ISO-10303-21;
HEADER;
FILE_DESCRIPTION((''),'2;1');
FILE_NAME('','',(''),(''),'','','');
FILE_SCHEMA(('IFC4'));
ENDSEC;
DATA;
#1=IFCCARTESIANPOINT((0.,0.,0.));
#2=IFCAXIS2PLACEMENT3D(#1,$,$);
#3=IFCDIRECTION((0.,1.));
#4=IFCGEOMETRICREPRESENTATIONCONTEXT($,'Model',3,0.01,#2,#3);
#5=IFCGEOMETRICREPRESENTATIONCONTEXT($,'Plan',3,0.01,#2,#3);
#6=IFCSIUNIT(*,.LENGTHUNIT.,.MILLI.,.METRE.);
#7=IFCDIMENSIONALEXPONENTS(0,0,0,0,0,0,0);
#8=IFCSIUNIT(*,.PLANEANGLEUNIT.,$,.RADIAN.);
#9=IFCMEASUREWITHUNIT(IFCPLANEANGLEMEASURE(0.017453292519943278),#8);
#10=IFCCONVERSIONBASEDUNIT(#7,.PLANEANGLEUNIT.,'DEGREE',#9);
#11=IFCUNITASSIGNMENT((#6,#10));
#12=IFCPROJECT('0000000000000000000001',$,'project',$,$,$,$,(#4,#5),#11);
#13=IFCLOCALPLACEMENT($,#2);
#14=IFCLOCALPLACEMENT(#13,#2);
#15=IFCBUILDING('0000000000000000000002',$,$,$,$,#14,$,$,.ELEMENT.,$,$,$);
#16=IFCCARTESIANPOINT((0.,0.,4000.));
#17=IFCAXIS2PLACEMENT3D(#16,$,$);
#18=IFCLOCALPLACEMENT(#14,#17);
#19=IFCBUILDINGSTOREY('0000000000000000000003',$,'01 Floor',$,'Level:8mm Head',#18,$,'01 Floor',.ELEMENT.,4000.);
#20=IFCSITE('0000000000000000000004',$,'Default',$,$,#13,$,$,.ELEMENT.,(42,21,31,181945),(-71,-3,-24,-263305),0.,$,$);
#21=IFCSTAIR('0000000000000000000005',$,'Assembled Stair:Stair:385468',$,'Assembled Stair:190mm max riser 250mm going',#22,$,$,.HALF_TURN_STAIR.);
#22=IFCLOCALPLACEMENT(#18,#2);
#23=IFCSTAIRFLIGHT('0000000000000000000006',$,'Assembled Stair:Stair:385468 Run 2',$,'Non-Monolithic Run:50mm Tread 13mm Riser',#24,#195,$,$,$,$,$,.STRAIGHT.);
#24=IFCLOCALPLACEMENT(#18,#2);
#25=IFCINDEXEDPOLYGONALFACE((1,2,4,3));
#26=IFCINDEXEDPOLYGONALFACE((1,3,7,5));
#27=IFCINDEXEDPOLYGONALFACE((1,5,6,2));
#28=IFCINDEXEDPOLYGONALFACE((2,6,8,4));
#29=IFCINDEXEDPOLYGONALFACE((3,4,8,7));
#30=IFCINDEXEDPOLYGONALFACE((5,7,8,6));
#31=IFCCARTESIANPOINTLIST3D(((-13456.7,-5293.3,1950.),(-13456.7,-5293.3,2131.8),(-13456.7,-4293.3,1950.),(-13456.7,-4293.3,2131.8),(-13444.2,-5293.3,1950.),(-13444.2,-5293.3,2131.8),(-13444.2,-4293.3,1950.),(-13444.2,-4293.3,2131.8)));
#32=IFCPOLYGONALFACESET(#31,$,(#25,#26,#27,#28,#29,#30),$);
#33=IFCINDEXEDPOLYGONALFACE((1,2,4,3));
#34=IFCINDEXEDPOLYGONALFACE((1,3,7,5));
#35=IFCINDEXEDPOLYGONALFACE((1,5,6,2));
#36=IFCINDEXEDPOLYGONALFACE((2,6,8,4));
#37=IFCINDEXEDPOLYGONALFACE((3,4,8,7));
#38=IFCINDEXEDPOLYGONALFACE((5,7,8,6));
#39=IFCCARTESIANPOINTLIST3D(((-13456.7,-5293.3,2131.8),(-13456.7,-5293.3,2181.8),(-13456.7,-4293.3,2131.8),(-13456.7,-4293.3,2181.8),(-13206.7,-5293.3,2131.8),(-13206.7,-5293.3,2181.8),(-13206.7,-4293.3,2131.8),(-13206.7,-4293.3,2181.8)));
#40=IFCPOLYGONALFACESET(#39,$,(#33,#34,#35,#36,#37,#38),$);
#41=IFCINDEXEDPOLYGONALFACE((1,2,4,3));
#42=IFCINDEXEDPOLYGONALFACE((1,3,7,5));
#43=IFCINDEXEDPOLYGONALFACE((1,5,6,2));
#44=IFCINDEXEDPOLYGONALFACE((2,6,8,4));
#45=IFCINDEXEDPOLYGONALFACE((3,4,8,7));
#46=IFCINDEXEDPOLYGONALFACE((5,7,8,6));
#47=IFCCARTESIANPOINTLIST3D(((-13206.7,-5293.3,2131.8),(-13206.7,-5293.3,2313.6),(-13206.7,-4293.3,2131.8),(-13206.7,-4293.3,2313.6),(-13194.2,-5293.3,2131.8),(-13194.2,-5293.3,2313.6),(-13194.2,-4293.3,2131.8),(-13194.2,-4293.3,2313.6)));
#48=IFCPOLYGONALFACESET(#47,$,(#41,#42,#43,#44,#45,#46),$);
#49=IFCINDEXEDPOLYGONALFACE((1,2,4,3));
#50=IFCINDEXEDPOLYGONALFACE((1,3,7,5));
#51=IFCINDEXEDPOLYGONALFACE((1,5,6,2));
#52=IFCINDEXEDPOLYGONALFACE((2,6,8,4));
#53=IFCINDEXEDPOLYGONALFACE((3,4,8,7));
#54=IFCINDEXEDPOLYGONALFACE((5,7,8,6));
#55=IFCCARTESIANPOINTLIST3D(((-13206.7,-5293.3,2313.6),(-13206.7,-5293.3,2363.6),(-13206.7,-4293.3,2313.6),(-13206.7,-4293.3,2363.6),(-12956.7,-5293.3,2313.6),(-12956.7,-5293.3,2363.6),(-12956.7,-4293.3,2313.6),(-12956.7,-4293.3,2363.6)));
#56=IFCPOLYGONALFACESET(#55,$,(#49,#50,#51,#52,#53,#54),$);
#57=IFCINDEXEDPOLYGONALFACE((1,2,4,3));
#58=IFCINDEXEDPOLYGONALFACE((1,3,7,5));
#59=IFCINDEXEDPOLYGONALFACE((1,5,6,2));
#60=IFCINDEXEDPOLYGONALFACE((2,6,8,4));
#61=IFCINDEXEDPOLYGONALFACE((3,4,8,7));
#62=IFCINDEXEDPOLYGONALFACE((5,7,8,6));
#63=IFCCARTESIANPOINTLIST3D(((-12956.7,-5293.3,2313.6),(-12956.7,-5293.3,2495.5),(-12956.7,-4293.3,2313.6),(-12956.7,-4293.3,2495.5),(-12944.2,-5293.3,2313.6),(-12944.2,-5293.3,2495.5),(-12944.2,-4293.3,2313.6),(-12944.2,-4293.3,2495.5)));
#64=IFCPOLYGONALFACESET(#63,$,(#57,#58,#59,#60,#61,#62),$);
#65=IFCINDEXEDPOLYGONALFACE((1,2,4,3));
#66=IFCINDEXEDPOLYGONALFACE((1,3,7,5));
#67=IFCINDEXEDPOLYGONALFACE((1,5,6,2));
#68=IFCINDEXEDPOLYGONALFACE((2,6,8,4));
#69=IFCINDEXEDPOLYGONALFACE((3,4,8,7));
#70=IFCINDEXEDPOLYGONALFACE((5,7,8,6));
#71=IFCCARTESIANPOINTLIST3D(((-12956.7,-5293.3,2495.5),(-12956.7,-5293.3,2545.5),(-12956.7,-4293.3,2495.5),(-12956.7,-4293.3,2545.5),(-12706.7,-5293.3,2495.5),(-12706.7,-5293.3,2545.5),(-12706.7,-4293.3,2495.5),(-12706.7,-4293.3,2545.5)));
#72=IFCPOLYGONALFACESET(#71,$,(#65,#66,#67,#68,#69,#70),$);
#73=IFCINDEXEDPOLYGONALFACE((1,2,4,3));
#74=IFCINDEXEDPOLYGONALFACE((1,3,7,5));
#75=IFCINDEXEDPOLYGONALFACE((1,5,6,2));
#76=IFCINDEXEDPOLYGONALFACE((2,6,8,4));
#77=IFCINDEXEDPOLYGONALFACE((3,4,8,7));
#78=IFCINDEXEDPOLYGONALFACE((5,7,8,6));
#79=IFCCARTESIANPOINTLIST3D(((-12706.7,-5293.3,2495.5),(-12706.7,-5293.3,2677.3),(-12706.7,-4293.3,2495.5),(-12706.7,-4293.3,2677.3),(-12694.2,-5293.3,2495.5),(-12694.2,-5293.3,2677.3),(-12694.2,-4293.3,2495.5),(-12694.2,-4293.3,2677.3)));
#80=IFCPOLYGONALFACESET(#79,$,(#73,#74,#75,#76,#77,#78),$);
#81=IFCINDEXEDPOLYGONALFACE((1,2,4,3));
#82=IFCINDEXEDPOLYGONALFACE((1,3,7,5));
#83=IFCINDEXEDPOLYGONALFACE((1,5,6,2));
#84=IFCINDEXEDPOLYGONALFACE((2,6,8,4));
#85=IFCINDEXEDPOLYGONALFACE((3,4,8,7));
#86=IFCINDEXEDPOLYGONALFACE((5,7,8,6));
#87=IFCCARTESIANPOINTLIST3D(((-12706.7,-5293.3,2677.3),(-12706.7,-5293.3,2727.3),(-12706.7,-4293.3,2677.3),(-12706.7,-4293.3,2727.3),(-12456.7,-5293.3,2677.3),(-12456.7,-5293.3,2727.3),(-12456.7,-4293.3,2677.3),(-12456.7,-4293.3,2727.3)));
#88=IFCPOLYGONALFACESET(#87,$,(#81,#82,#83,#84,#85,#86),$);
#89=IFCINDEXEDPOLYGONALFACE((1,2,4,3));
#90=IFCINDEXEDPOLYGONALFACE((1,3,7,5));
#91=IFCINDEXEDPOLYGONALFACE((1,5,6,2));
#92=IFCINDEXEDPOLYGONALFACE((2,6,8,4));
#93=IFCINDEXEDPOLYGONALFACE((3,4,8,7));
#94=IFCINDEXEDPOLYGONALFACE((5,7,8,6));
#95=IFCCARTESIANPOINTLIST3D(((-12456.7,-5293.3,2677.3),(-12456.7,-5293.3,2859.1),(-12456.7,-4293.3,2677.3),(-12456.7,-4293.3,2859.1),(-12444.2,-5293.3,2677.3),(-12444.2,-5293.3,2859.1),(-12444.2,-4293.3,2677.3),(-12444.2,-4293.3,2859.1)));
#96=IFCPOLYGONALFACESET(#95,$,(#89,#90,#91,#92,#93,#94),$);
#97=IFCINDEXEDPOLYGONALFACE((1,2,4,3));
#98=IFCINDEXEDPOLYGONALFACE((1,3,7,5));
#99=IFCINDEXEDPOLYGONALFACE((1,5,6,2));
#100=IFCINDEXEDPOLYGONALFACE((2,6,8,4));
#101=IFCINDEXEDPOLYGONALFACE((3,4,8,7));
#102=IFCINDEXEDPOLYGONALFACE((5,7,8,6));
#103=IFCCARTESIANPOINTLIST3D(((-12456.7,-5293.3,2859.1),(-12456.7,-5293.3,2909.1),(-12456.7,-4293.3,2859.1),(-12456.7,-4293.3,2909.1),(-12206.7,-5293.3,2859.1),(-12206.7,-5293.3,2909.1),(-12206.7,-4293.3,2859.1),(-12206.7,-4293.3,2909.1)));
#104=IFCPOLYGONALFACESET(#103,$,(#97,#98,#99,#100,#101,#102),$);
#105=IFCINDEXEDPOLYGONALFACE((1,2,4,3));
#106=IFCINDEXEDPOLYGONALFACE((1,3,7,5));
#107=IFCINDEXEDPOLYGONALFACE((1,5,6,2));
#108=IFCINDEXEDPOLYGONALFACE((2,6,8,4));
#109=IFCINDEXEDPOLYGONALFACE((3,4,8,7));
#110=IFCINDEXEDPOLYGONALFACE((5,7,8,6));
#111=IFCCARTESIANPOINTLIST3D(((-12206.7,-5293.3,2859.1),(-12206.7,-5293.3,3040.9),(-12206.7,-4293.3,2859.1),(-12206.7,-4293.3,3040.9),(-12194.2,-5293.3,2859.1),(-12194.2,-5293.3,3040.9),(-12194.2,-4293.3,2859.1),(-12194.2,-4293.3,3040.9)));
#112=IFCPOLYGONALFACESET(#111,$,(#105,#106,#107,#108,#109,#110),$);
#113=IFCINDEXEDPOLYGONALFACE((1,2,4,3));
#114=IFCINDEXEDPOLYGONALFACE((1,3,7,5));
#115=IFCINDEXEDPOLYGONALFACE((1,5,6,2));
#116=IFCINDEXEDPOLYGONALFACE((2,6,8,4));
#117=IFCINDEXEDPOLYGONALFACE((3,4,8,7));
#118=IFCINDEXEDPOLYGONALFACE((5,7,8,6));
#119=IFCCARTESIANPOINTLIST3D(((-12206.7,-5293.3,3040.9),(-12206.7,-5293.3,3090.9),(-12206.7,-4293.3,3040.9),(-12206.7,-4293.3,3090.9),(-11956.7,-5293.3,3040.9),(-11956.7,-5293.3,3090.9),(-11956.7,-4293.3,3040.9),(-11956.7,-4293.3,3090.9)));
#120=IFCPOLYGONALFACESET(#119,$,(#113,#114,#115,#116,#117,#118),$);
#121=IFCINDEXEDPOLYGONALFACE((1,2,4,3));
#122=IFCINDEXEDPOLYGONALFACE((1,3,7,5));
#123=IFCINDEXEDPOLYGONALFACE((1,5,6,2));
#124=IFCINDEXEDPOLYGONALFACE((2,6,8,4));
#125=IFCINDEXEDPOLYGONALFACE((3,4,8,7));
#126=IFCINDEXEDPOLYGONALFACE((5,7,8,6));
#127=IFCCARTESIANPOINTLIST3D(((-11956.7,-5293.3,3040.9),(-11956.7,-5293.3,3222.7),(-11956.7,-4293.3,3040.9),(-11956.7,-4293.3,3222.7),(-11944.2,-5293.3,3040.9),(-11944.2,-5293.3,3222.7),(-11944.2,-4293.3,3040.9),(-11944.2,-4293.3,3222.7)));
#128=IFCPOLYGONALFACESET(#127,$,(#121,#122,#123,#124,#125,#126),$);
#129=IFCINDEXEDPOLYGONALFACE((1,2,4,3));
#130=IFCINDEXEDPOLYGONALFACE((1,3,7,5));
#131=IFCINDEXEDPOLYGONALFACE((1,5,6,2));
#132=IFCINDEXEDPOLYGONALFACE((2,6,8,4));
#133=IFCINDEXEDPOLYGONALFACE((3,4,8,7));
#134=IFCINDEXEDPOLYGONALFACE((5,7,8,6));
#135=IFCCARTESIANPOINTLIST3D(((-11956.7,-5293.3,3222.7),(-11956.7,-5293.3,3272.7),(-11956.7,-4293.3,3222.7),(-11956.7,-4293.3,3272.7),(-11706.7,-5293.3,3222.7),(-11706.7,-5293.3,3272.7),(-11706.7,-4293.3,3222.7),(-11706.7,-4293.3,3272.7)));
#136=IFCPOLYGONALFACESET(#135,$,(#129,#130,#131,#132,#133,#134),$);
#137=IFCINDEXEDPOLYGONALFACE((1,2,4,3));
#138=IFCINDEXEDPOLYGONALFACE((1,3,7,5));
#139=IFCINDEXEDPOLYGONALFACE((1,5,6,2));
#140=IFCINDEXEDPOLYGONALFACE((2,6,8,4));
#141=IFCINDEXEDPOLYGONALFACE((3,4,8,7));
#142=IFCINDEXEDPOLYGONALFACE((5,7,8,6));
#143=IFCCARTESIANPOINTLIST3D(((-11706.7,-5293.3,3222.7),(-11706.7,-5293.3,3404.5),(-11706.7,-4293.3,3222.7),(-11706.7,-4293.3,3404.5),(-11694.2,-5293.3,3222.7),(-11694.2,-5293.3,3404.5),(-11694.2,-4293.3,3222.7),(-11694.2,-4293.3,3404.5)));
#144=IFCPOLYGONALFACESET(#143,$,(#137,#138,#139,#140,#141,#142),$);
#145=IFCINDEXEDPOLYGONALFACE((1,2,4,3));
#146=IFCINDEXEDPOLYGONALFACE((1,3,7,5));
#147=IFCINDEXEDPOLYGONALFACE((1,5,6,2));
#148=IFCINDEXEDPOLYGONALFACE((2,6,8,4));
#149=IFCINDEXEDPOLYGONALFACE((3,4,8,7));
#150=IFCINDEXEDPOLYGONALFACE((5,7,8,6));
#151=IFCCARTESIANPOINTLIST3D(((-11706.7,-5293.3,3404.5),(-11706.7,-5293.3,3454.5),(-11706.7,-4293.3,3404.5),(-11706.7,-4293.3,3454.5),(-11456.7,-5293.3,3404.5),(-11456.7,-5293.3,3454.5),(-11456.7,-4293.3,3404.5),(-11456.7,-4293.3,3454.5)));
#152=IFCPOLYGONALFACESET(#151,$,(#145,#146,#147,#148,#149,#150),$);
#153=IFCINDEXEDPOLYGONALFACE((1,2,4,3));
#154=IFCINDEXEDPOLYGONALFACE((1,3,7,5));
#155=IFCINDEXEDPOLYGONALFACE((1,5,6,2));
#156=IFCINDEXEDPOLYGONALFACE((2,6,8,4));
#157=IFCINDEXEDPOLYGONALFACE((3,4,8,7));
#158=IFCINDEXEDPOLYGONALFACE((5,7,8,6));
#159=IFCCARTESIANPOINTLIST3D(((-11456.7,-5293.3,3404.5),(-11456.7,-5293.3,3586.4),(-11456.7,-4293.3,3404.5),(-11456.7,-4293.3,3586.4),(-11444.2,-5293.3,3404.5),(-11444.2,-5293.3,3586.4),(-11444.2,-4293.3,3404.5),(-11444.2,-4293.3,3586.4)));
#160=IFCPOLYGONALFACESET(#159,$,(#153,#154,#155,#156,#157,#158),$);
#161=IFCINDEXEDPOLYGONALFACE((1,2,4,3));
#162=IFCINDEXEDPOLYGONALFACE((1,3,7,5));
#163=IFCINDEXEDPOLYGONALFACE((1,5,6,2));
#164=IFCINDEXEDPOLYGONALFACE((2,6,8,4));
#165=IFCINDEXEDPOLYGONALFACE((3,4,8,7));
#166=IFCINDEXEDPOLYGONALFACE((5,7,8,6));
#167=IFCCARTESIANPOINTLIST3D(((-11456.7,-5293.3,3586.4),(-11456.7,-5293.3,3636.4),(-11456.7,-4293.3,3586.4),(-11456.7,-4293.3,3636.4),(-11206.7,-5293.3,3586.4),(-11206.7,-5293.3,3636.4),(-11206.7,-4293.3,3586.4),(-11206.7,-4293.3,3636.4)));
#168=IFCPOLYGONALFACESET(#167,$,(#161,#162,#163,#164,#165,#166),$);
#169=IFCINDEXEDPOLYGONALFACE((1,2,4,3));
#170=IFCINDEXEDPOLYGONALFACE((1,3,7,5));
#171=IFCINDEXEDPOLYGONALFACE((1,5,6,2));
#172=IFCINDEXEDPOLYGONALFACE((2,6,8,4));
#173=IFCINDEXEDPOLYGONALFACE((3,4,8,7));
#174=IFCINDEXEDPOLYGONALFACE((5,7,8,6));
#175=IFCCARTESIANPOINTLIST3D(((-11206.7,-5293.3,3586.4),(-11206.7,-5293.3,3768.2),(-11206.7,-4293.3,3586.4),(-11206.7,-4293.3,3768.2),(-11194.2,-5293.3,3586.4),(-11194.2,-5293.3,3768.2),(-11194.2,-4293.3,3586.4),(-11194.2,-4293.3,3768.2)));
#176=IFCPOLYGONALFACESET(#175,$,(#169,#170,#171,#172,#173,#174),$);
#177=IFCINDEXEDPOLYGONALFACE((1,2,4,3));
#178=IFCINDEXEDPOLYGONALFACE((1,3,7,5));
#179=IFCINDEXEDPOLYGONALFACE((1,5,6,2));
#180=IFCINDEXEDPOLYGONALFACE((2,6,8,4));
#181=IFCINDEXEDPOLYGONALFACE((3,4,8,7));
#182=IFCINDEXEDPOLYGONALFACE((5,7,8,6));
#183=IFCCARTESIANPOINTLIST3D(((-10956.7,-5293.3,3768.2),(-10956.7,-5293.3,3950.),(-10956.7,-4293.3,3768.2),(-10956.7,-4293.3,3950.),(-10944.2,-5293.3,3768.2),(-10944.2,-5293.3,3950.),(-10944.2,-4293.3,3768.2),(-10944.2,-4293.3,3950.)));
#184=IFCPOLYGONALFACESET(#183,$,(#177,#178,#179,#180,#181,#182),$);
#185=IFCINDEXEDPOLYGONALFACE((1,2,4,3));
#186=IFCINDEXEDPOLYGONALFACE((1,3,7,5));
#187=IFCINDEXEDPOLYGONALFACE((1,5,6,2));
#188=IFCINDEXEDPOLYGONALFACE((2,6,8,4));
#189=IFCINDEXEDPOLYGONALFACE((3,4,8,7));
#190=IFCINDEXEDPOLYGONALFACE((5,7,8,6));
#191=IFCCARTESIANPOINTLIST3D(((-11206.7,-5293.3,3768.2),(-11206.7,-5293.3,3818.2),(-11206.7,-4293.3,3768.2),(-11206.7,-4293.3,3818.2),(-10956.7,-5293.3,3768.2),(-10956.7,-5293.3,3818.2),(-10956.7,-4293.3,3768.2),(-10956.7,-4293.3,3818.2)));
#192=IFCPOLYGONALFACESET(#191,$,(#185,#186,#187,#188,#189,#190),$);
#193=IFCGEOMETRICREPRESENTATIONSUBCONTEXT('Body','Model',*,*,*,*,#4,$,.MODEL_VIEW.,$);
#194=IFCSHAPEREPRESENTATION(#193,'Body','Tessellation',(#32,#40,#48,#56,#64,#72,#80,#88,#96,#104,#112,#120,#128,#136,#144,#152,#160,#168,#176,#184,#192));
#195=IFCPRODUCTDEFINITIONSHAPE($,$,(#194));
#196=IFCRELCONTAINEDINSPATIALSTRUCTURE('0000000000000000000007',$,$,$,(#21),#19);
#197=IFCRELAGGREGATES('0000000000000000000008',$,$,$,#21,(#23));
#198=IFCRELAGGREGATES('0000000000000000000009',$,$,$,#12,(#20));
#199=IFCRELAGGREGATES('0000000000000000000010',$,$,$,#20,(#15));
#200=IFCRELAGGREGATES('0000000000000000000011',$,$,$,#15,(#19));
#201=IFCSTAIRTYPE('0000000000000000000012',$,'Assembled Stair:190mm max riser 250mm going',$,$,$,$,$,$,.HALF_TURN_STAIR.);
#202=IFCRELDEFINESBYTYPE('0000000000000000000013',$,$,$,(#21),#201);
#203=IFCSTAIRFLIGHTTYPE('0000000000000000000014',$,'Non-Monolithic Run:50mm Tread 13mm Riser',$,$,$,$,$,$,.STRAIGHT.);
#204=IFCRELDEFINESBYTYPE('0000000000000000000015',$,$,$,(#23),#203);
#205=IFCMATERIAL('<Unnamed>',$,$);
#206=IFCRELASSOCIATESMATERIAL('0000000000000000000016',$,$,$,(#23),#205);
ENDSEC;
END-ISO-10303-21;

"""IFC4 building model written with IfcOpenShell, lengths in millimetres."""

from ifc_helpers import new_model, entity, si_unit, converted_unit, direction, frame, origin, place, context, subcontext, project, spatial, indexed_curve, outline, extrude, material, type_object, element, aggregate, save


model = new_model("IFC4")

# Units and contexts
model_context = context("Model", 3, precision=0.01, world=origin(), true_north=direction((0.0, 1.0)))
plan_context = context("Plan", 3, precision=0.01, world=origin(), true_north=direction((0.0, 1.0)))
body_context = subcontext(model_context, "Body", "Model", "MODEL_VIEW")
ifc_project = project(units=[si_unit("LENGTHUNIT", "METRE", prefix="MILLI"), converted_unit("PLANEANGLEUNIT", "DEGREE", entity("IfcPlaneAngleMeasure", 0.017453292519943278), si_unit("PLANEANGLEUNIT", "RADIAN"), dimensions=[0, 0, 0, 0, 0, 0, 0])], contexts=[model_context, plan_context])

# Site, building, storey
site_placement = place(None, origin())
site = spatial("IfcSite", under=ifc_project, at=site_placement, Name="Default", CompositionType="ELEMENT", RefLatitude=(42, 21, 31, 181945), RefLongitude=(-71, -3, -24, -263305), RefElevation=0.0)
building_placement = place(site_placement, origin())
building = spatial("IfcBuilding", under=site, at=building_placement, CompositionType="ELEMENT")
storey_placement = place(building_placement, frame((0.0, 0.0, 4000.0)))
storey = spatial("IfcBuildingStorey", under=building, at=storey_placement, Name="01 Floor", ObjectType="Level:8mm Head", LongName="01 Floor", CompositionType="ELEMENT", Elevation=4000.0)

# Stair
stair_type = type_object("IfcStairType", Name="Assembled Stair:190mm max riser 250mm going", PredefinedType="HALF_TURN_STAIR")
stair_placement = place(storey_placement, origin())
stair = element("IfcStair", 1, at=stair_placement, inside=storey, type_object=stair_type, Name="Assembled Stair:Stair:385468", ObjectType="Assembled Stair:190mm max riser 250mm going", PredefinedType="HALF_TURN_STAIR")
ifc_material_1 = material(Name="<Unnamed>")

# Stair flight
stair_flight_type = type_object("IfcStairFlightType", Name="Non-Monolithic Run:50mm Tread 13mm Riser", PredefinedType="STRAIGHT")
stair_flight_1_placement = place(stair_placement, origin())
stair_flight_1 = element("IfcStairFlight", 2, at=stair_flight_1_placement, type_object=stair_flight_type, material=ifc_material_1, Name="Assembled Stair:Stair:385468 Run 2", ObjectType="Non-Monolithic Run:50mm Tread 13mm Riser", PredefinedType="STRAIGHT", context=body_context, shape_type="SweptSolid", body=[
    extrude(outline(indexed_curve([(-500.0, -6.3), (500.0, -6.3), (500.0, 6.2), (-500.0, 6.2), (-500.0, -6.3)], self_intersect=False)), frame((-13450.4, -4793.3, 1950.0), z_axis=(0.0, 0.0, 1.0), x_axis=(0.0, 1.0, 0.0)), (0.0, 0.0, 1.0), 181.8),
    extrude(outline(indexed_curve([(-125.0, -500.0), (125.0, -500.0), (125.0, 500.0), (-125.0, 500.0), (-125.0, -500.0)], self_intersect=False)), frame((-13331.7, -4793.3, 2131.8), z_axis=(0.0, 0.0, 1.0), x_axis=(-1.0, 0.0, 0.0)), (0.0, 0.0, 1.0), 50.0),
    extrude(outline(indexed_curve([(-500.0, -6.2), (500.0, -6.2), (500.0, 6.2), (-500.0, 6.2), (-500.0, -6.2)], self_intersect=False)), frame((-13200.4, -4793.3, 2131.8), z_axis=(0.0, 0.0, 1.0), x_axis=(0.0, 1.0, 0.0)), (0.0, 0.0, 1.0), 181.8),
    extrude(outline(indexed_curve([(-125.0, -500.0), (125.0, -500.0), (125.0, 500.0), (-125.0, 500.0), (-125.0, -500.0)], self_intersect=False)), frame((-13081.7, -4793.3, 2313.6), z_axis=(0.0, 0.0, 1.0), x_axis=(-1.0, 0.0, 0.0)), (0.0, 0.0, 1.0), 50.0),
    extrude(outline(indexed_curve([(-500.0, -6.2), (500.0, -6.2), (500.0, 6.3), (-500.0, 6.3), (-500.0, -6.2)], self_intersect=False)), frame((-12950.4, -4793.3, 2313.6), z_axis=(0.0, 0.0, 1.0), x_axis=(0.0, 1.0, 0.0)), (0.0, 0.0, 1.0), 181.8),
    extrude(outline(indexed_curve([(-125.0, -500.0), (125.0, -500.0), (125.0, 500.0), (-125.0, 500.0), (-125.0, -500.0)], self_intersect=False)), frame((-12831.7, -4793.3, 2495.5), z_axis=(0.0, 0.0, 1.0), x_axis=(-1.0, 0.0, 0.0)), (0.0, 0.0, 1.0), 50.0),
    extrude(outline(indexed_curve([(-500.0, -6.2), (500.0, -6.2), (500.0, 6.2), (-500.0, 6.2), (-500.0, -6.2)], self_intersect=False)), frame((-12700.4, -4793.3, 2495.5), z_axis=(0.0, 0.0, 1.0), x_axis=(0.0, 1.0, 0.0)), (0.0, 0.0, 1.0), 181.8),
    extrude(outline(indexed_curve([(-125.0, -500.0), (125.0, -500.0), (125.0, 500.0), (-125.0, 500.0), (-125.0, -500.0)], self_intersect=False)), frame((-12581.7, -4793.3, 2677.3), z_axis=(0.0, 0.0, 1.0), x_axis=(-1.0, 0.0, 0.0)), (0.0, 0.0, 1.0), 50.0),
    extrude(outline(indexed_curve([(-500.0, -6.2), (500.0, -6.2), (500.0, 6.3), (-500.0, 6.3), (-500.0, -6.2)], self_intersect=False)), frame((-12450.4, -4793.3, 2677.3), z_axis=(0.0, 0.0, 1.0), x_axis=(0.0, 1.0, 0.0)), (0.0, 0.0, 1.0), 181.8),
    extrude(outline(indexed_curve([(-125.0, -500.0), (125.0, -500.0), (125.0, 500.0), (-125.0, 500.0), (-125.0, -500.0)], self_intersect=False)), frame((-12331.7, -4793.3, 2859.1), z_axis=(0.0, 0.0, 1.0), x_axis=(-1.0, 0.0, 0.0)), (0.0, 0.0, 1.0), 50.0),
    extrude(outline(indexed_curve([(-500.0, -6.2), (500.0, -6.2), (500.0, 6.2), (-500.0, 6.2), (-500.0, -6.2)], self_intersect=False)), frame((-12200.4, -4793.3, 2859.1), z_axis=(0.0, 0.0, 1.0), x_axis=(0.0, 1.0, 0.0)), (0.0, 0.0, 1.0), 181.8),
    extrude(outline(indexed_curve([(-125.0, -500.0), (125.0, -500.0), (125.0, 500.0), (-125.0, 500.0), (-125.0, -500.0)], self_intersect=False)), frame((-12081.7, -4793.3, 3040.9), z_axis=(0.0, 0.0, 1.0), x_axis=(-1.0, 0.0, 0.0)), (0.0, 0.0, 1.0), 50.0),
    extrude(outline(indexed_curve([(-500.0, -6.2), (500.0, -6.2), (500.0, 6.3), (-500.0, 6.3), (-500.0, -6.2)], self_intersect=False)), frame((-11950.4, -4793.3, 3040.9), z_axis=(0.0, 0.0, 1.0), x_axis=(0.0, 1.0, 0.0)), (0.0, 0.0, 1.0), 181.8),
    extrude(outline(indexed_curve([(-125.0, -500.0), (125.0, -500.0), (125.0, 500.0), (-125.0, 500.0), (-125.0, -500.0)], self_intersect=False)), frame((-11831.7, -4793.3, 3222.7), z_axis=(0.0, 0.0, 1.0), x_axis=(-1.0, 0.0, 0.0)), (0.0, 0.0, 1.0), 50.0),
    extrude(outline(indexed_curve([(-500.0, -6.2), (500.0, -6.2), (500.0, 6.2), (-500.0, 6.2), (-500.0, -6.2)], self_intersect=False)), frame((-11700.4, -4793.3, 3222.7), z_axis=(0.0, 0.0, 1.0), x_axis=(0.0, 1.0, 0.0)), (0.0, 0.0, 1.0), 181.8),
    extrude(outline(indexed_curve([(-125.0, -500.0), (125.0, -500.0), (125.0, 500.0), (-125.0, 500.0), (-125.0, -500.0)], self_intersect=False)), frame((-11581.7, -4793.3, 3404.5), z_axis=(0.0, 0.0, 1.0), x_axis=(-1.0, 0.0, 0.0)), (0.0, 0.0, 1.0), 50.0),
    extrude(outline(indexed_curve([(-500.0, -6.2), (500.0, -6.2), (500.0, 6.3), (-500.0, 6.3), (-500.0, -6.2)], self_intersect=False)), frame((-11450.4, -4793.3, 3404.5), z_axis=(0.0, 0.0, 1.0), x_axis=(0.0, 1.0, 0.0)), (0.0, 0.0, 1.0), 181.8),
    extrude(outline(indexed_curve([(-125.0, -500.0), (125.0, -500.0), (125.0, 500.0), (-125.0, 500.0), (-125.0, -500.0)], self_intersect=False)), frame((-11331.7, -4793.3, 3586.4), z_axis=(0.0, 0.0, 1.0), x_axis=(-1.0, 0.0, 0.0)), (0.0, 0.0, 1.0), 50.0),
    extrude(outline(indexed_curve([(-500.0, -6.2), (500.0, -6.2), (500.0, 6.2), (-500.0, 6.2), (-500.0, -6.2)], self_intersect=False)), frame((-11200.4, -4793.3, 3586.4), z_axis=(0.0, 0.0, 1.0), x_axis=(0.0, 1.0, 0.0)), (0.0, 0.0, 1.0), 181.8),
    extrude(outline(indexed_curve([(-500.0, -6.2), (500.0, -6.2), (500.0, 6.3), (-500.0, 6.3), (-500.0, -6.2)], self_intersect=False)), frame((-10950.4, -4793.3, 3768.2), z_axis=(0.0, 0.0, 1.0), x_axis=(0.0, 1.0, 0.0)), (0.0, 0.0, 1.0), 181.8),
    extrude(outline(indexed_curve([(-125.0, -500.0), (125.0, -500.0), (125.0, 500.0), (-125.0, 500.0), (-125.0, -500.0)], self_intersect=False)), frame((-11081.7, -4793.3, 3768.2), z_axis=(0.0, 0.0, 1.0), x_axis=(-1.0, 0.0, 0.0)), (0.0, 0.0, 1.0), 50.0),
])
aggregate(stair, [stair_flight_1])

save(model, "model.ifc")
